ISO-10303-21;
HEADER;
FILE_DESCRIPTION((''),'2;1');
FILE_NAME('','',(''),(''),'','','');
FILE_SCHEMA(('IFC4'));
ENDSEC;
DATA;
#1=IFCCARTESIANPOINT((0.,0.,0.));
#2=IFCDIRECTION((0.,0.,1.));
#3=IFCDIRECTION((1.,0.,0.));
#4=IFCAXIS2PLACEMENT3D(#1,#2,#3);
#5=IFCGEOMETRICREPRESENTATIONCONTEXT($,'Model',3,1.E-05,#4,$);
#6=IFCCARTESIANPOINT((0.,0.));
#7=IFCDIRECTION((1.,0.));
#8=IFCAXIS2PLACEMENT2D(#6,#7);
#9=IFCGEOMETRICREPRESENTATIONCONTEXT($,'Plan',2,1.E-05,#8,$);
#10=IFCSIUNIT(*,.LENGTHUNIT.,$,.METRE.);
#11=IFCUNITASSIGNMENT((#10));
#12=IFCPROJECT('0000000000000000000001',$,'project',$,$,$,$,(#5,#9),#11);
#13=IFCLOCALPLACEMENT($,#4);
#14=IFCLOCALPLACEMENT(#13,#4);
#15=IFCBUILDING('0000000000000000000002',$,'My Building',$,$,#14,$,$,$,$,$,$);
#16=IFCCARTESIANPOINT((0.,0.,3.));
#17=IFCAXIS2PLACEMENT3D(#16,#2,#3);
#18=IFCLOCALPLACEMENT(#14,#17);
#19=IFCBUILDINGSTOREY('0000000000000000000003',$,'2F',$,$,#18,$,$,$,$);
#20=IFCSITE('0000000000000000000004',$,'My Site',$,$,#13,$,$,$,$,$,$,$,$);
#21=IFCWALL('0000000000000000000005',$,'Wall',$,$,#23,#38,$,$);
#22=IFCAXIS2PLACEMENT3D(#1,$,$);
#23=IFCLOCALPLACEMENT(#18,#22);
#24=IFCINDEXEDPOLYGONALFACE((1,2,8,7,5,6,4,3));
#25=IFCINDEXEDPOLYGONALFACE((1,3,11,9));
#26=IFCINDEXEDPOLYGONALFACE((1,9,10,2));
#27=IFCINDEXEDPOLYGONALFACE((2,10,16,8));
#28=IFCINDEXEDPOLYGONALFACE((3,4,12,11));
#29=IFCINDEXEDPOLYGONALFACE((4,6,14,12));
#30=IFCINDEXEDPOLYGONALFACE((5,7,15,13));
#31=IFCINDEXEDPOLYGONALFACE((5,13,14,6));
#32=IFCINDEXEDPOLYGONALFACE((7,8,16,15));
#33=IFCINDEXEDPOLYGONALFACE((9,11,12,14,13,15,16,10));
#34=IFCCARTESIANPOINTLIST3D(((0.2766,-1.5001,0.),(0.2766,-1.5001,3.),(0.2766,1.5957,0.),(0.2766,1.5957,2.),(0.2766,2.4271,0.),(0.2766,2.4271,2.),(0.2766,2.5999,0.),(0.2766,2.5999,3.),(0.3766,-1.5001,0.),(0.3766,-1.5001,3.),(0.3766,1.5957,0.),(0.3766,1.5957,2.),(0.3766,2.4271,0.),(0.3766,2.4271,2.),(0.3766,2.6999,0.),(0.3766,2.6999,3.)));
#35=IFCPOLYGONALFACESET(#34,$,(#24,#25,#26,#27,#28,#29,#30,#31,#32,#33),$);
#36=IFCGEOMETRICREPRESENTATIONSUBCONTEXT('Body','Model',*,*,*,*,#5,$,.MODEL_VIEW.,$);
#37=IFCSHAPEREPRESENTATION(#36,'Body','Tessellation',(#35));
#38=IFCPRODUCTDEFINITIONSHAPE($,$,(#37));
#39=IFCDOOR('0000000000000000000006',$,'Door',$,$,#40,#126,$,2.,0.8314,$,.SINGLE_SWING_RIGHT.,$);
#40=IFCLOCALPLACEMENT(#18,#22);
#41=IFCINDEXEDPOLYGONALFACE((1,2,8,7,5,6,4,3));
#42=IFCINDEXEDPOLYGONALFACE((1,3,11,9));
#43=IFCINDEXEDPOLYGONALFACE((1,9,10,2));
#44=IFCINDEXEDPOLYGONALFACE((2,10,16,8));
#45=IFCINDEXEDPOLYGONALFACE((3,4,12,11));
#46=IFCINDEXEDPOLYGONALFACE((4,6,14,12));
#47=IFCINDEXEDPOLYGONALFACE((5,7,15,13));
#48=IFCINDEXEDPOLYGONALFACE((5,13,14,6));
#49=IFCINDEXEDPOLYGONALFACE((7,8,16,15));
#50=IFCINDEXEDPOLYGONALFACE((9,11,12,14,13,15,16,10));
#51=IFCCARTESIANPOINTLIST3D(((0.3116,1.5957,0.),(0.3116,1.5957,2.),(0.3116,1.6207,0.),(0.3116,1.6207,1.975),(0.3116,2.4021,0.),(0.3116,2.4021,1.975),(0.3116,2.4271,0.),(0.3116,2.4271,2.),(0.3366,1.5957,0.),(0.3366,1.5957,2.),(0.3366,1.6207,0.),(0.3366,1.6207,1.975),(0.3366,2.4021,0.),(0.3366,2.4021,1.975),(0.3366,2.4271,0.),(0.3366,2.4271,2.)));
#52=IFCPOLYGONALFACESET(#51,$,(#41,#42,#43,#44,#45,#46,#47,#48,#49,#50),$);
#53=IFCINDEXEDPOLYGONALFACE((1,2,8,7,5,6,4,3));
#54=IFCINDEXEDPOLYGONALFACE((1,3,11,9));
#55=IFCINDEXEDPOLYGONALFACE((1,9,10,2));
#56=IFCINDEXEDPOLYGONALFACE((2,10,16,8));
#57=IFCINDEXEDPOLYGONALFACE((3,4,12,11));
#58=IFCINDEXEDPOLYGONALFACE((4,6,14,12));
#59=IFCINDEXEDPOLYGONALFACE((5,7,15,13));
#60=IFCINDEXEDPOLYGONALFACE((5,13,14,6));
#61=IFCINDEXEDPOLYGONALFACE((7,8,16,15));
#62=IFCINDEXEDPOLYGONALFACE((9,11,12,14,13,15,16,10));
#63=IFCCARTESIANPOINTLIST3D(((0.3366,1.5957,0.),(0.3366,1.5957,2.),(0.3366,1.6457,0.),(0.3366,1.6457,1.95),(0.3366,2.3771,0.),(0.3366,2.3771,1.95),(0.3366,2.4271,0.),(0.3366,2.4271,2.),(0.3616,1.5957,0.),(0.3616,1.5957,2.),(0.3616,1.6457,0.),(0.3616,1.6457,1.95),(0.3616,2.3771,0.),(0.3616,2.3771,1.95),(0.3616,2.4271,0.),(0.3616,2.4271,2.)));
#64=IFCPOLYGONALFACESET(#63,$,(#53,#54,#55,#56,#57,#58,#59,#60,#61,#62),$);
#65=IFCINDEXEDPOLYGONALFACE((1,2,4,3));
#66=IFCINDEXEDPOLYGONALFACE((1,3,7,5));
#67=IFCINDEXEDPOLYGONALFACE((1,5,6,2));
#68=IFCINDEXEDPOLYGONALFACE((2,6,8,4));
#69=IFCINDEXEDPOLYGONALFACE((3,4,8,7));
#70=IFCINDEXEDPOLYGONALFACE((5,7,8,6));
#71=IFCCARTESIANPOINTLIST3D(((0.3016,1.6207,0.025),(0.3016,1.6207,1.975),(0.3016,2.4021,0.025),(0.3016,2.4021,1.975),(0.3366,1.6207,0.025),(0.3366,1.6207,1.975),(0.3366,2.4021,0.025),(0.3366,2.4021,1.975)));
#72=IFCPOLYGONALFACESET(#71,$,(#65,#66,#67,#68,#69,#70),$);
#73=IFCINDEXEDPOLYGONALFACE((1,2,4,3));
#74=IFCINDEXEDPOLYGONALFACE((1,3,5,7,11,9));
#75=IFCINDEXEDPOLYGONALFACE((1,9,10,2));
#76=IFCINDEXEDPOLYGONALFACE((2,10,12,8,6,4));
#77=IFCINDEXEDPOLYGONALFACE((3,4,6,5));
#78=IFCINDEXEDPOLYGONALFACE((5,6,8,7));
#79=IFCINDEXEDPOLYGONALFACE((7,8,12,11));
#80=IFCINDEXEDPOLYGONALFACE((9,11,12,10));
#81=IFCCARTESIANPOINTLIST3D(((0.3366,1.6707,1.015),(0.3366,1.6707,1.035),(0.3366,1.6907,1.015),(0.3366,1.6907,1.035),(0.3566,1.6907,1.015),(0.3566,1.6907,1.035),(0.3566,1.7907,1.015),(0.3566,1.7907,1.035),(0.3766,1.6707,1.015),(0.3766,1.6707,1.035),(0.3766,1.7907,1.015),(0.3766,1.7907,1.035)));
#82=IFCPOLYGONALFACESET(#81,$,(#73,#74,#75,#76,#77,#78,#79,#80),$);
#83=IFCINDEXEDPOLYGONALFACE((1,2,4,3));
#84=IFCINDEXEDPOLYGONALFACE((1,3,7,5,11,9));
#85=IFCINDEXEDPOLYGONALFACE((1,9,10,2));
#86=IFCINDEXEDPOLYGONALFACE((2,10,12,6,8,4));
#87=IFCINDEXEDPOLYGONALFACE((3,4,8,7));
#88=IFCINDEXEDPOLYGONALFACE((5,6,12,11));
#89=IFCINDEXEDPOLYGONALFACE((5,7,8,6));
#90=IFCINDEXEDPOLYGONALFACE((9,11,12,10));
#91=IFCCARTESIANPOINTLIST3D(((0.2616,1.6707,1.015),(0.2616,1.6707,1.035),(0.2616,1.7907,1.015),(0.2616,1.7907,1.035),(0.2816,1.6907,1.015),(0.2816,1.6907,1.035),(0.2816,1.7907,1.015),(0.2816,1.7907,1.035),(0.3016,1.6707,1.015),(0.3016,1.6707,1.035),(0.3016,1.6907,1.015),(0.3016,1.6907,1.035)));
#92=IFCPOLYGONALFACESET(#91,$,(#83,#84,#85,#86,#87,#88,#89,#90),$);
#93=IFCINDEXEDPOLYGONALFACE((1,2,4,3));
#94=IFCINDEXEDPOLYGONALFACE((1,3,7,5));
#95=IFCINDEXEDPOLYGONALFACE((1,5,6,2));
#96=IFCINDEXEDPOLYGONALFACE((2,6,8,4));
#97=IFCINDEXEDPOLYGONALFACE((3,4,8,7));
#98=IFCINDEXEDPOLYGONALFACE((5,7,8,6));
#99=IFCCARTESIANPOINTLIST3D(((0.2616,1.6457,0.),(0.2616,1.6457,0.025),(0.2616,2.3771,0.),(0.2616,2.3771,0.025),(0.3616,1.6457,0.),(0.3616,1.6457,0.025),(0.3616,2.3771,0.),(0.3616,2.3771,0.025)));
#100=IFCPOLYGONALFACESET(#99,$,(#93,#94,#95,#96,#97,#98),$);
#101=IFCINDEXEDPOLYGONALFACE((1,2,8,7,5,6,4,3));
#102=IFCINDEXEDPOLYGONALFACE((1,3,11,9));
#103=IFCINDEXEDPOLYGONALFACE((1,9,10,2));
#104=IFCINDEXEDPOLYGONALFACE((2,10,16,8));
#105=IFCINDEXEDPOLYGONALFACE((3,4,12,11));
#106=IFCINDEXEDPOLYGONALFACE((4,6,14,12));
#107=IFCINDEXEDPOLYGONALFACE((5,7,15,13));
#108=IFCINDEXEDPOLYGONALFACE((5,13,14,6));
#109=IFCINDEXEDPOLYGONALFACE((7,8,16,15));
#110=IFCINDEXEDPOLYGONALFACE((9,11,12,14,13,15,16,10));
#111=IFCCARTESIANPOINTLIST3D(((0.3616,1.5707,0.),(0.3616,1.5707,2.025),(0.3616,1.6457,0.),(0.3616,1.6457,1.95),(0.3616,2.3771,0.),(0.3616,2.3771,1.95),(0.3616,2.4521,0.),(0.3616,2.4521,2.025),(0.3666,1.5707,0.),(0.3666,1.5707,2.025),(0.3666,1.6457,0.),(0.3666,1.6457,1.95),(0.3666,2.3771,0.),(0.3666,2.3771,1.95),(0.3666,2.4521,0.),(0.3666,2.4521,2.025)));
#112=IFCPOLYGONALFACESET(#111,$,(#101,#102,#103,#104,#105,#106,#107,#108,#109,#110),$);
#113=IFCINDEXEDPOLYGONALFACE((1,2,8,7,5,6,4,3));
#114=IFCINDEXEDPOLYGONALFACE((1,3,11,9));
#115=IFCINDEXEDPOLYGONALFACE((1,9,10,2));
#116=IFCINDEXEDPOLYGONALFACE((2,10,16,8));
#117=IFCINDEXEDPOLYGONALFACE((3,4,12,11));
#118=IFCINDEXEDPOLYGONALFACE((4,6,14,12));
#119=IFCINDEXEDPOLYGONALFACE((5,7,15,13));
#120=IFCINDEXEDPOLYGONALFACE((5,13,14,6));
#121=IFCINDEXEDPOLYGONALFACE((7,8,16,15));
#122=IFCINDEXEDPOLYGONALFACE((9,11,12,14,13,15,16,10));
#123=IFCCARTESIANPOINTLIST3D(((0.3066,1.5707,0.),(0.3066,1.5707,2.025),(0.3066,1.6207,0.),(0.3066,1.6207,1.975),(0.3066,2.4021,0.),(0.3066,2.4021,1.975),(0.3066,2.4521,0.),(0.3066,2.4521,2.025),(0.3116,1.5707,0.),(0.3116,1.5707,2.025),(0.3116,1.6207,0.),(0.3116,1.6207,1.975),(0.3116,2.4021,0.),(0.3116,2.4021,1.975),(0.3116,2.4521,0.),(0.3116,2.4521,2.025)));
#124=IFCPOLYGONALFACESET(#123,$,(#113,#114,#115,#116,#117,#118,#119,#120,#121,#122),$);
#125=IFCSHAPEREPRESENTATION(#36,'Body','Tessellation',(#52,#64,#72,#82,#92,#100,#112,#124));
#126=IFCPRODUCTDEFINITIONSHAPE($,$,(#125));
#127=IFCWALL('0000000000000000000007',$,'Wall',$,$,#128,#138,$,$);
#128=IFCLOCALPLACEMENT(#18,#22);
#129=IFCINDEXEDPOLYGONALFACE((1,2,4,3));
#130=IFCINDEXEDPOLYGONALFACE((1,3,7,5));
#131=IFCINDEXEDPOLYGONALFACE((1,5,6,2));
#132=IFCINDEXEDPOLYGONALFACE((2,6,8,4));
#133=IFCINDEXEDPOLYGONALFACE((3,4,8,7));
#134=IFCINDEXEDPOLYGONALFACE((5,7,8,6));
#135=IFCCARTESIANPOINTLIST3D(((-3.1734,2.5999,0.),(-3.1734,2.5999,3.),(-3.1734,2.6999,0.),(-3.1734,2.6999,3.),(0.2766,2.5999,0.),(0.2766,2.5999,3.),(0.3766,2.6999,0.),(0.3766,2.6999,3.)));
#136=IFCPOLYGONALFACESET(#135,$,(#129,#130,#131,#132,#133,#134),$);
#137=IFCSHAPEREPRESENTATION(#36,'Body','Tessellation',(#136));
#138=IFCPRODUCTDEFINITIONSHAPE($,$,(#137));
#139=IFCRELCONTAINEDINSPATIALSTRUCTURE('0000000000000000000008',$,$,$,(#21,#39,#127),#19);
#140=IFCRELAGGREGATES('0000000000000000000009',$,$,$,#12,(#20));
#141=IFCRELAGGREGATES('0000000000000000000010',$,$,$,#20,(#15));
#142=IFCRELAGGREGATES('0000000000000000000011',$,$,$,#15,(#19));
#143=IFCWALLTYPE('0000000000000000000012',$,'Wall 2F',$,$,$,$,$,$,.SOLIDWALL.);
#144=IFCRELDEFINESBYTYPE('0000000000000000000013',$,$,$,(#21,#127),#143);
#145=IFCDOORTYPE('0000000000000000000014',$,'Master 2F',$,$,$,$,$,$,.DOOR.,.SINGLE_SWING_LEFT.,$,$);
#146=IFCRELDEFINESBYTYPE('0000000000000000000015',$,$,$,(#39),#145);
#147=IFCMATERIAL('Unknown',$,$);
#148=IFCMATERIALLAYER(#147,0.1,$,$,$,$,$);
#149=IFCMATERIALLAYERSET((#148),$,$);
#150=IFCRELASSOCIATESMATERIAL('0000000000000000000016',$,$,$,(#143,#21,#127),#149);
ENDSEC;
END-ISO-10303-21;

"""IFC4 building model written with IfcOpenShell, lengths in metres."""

from ifc_helpers import new_model, entity, si_unit, frame, origin_with_axes, origin_2d_with_axis, place, context, subcontext, project, spatial, line, indexed_curve, outline, extrude, shape, source, transform, mapped, material, layer, layer_set, layer_usage, type_object, type_shapes, element, fill, save


model = new_model("IFC4")

# Units and contexts
model_context = context("Model", 3, precision=1e-05, world=origin_with_axes())
plan_context = context("Plan", 2, precision=1e-05, world=origin_2d_with_axis())
body_context_1 = subcontext(model_context, "Body", "Model", "MODEL_VIEW")
body_context_2 = subcontext(plan_context, "Body", "Plan", "PLAN_VIEW")
ifc_project = project(units=[si_unit("LENGTHUNIT", "METRE")], contexts=[model_context, plan_context])

# Site, building, storey
site_placement = place(None, origin_with_axes())
site = spatial("IfcSite", under=ifc_project, at=site_placement, Name="My Site")
building_placement = place(site_placement, origin_with_axes())
building = spatial("IfcBuilding", under=site, at=building_placement, Name="My Building")
storey_placement = place(building_placement, frame((0.0, 0.0, 3.0), z_axis=(0.0, 0.0, 1.0), x_axis=(1.0, 0.0, 0.0)))
storey = spatial("IfcBuildingStorey", under=building, at=storey_placement, Name="2F")

# Shared definitions
ifc_material = material(Name="Unknown")
ifc_layer_1 = layer(ifc_material, 0.1)
ifc_layer_set_1 = layer_set([ifc_layer_1])
wall_type_1 = type_object("IfcWallType", Name="Wall 2F", PredefinedType="SOLIDWALL", material=ifc_layer_set_1)

# Wall, opening, door
ifc_layer_usage_1 = layer_usage(ifc_layer_set_1, "AXIS2", "POSITIVE", 0.0)
wall_1_placement = place(storey_placement, frame((0.3766, -1.6001, 0.0), z_axis=(0.0, 0.0, 1.0), x_axis=(0.0, 1.0, 0.0)))
wall_1 = element("IfcWall", 1, at=wall_1_placement, inside=storey, type_object=wall_type_1, material=ifc_layer_usage_1, Name="Wall", context=body_context_1, shape_type="SweptSolid", body=[
    extrude(outline(indexed_curve([(0.1, 0.0), (0.1, 0.1), (4.2, 0.1), (4.3, 0.0)], segments=[line(1, 2, 3, 4, 1)])), origin_with_axes(), (0.0, 0.0, 1.0), 3.0),
])
shared_shape_1 = source(origin_with_axes(), body_context_1, "Body", "SweptSolid", [
    extrude(outline(indexed_curve([(0.0, 0.0), (0.8314, 0.0), (0.8314, 2.0), (0.0, 2.0)], segments=[line(1, 2, 3, 4, 1)])), frame((0.0, -0.6, 0.0), z_axis=(0.0, -1.0, 0.0), x_axis=(1.0, 0.0, 0.0)), (0.0, 0.0, -1.0), 1.2),
])
opening_1_placement = place(wall_1_placement, frame((3.1958, 0.015, 0.0), z_axis=(0.0, 0.0, 1.0), x_axis=(1.0, 0.0, 0.0)))
opening_1 = element("IfcOpeningElement", 2, at=opening_1_placement, cuts=wall_1, PredefinedType="OPENING", context=body_context_1, shape_type="MappedRepresentation", body=[
    mapped(shared_shape_1, transform((0.0, 0.0, 0.0), x_axis=(1.0, 0.0, 0.0), y_axis=(0.0, 1.0, 0.0), z_axis=(0.0, 0.0, 1.0), scale=1.0)),
])
door_type_1 = type_object("IfcDoorType", Name="Master 2F", OperationType="SINGLE_SWING_LEFT", PredefinedType="DOOR")
shared_shape_2 = source(origin_with_axes(), body_context_1, "Body", "SweptSolid", [
    extrude(outline(indexed_curve([(0.0, 0.0), (0.0, 2.0), (0.8314, 2.0), (0.8314, 0.0), (0.8064, 0.0), (0.8064, 1.975), (0.025, 1.975), (0.025, 0.0)], segments=[line(1, 2, 3, 4, 5, 6, 7, 8, 1)])), frame((0.0, 0.025, 0.0), z_axis=(0.0, -1.0, 0.0), x_axis=(1.0, 0.0, 0.0)), (0.0, 0.0, -1.0), 0.025),
    extrude(outline(indexed_curve([(0.0, 0.0), (0.0, 2.0), (0.8314, 2.0), (0.8314, 0.0), (0.7814, 0.0), (0.7814, 1.95), (0.05, 1.95), (0.05, 0.0)], segments=[line(1, 2, 3, 4, 5, 6, 7, 8, 1)])), frame((0.0, 0.0, 0.0), z_axis=(0.0, -1.0, 0.0), x_axis=(1.0, 0.0, 0.0)), (0.0, 0.0, -1.0), 0.025),
    extrude(outline(indexed_curve([(0.0, 0.0), (0.7814, 0.0), (0.7814, 0.035), (0.0, 0.035)], segments=[line(1, 2, 3, 4, 1)])), frame((0.025, 0.025, 0.025), z_axis=(0.0, 0.0, 1.0), x_axis=(1.0, 0.0, 0.0)), (0.0, 0.0, 1.0), 1.95),
    extrude(outline(indexed_curve([(0.0, 0.0), (0.0, -0.04), (0.12, -0.04), (0.12, -0.02), (0.02, -0.02), (0.02, 0.0)], segments=[line(1, 2, 3, 4, 5, 6, 1)])), frame((0.075, 0.025, 1.015), z_axis=(0.0, 0.0, 1.0), x_axis=(1.0, 0.0, 0.0)), (0.0, 0.0, 1.0), 0.02),
    extrude(outline(indexed_curve([(0.0, 0.0), (0.0, 0.04), (0.12, 0.04), (0.12, 0.02), (0.02, 0.02), (0.02, 0.0)], segments=[line(1, 2, 3, 4, 5, 6, 1)])), frame((0.075, 0.06, 1.015), z_axis=(0.0, 0.0, 1.0), x_axis=(1.0, 0.0, 0.0)), (0.0, 0.0, 1.0), 0.02),
    extrude(outline(indexed_curve([(0.0, 0.0), (0.7314, 0.0), (0.7314, 0.1), (0.0, 0.1)], segments=[line(1, 2, 3, 4, 1)])), frame((0.05, 0.0, 0.0), z_axis=(0.0, 0.0, 1.0), x_axis=(1.0, 0.0, 0.0)), (0.0, 0.0, 1.0), 0.025),
    extrude(outline(indexed_curve([(0.0, 0.0), (0.0, 2.025), (0.8814, 2.025), (0.8814, 0.0), (0.8064, 0.0), (0.8064, 1.95), (0.075, 1.95), (0.075, 0.0)], segments=[line(1, 2, 3, 4, 5, 6, 7, 8, 1)])), frame((-0.025, -0.005, 0.0), z_axis=(0.0, -1.0, 0.0), x_axis=(1.0, 0.0, 0.0)), (0.0, 0.0, -1.0), 0.005),
    extrude(outline(indexed_curve([(0.0, 0.0), (0.0, 2.025), (0.8814, 2.025), (0.8814, 0.0), (0.8314, 0.0), (0.8314, 1.975), (0.05, 1.975), (0.05, 0.0)], segments=[line(1, 2, 3, 4, 5, 6, 7, 8, 1)])), frame((-0.025, 0.05, 0.0), z_axis=(0.0, -1.0, 0.0), x_axis=(1.0, 0.0, 0.0)), (0.0, 0.0, -1.0), 0.005),
])
shared_shape_3 = source(origin_with_axes(), body_context_2, "Body", "Curve2D", [
    entity("IfcIndexedPolyCurve", entity("IfcCartesianPointList2D", [[0.0, 0.0], [0.0, 0.05], [0.025, 0.05], [0.025, 0.025], [0.05, 0.025], [0.05, 0.0]]), [entity("IfcLineIndex", [1, 2, 3, 4, 5, 6, 1])]),
    entity("IfcIndexedPolyCurve", entity("IfcCartesianPointList2D", [[0.8314, 0.0], [0.8314, 0.05], [0.8064, 0.05], [0.8064, 0.025], [0.7814, 0.025], [0.7814, 0.0]]), [entity("IfcLineIndex", [1, 2, 3, 4, 5, 6, 1])]),
    entity("IfcTrimmedCurve", entity("IfcEllipse", entity("IfcAxis2Placement2D", entity("IfcCartesianPoint", [0.7714, 0.05]), entity("IfcDirection", [1.0, 0.0])), 0.7464, 0.7814), [entity("IfcCartesianPoint", [0.7714, 0.8314])], [entity("IfcCartesianPoint", [0.025, 0.05])], True, "CARTESIAN"),
    entity("IfcIndexedPolyCurve", entity("IfcCartesianPointList2D", [[0.8064, 0.05], [0.7714, 0.05], [0.7714, 0.8314], [0.8064, 0.8314]]), [entity("IfcLineIndex", [1, 2, 3, 4, 1])]),
])
type_shapes(door_type_1, [shared_shape_2, shared_shape_3])
door_1_placement = place(opening_1_placement, frame((0.0, 0.0, 0.0), z_axis=(0.0, 0.0, 1.0), x_axis=(1.0, 0.0, 0.0)))
door_1 = element("IfcDoor", 3, at=door_1_placement, inside=storey, type_object=door_type_1, Name="Door", OperationType="SINGLE_SWING_RIGHT", OverallHeight=2.0, OverallWidth=0.8314, shapes=[
    shape(body_context_1, "Body", "MappedRepresentation", [mapped(shared_shape_2, transform((0.0, 0.0, 0.0), x_axis=(1.0, 0.0, 0.0), y_axis=(0.0, 1.0, 0.0), z_axis=(0.0, 0.0, 1.0), scale=1.0))]),
    shape(body_context_2, "Body", "MappedRepresentation", [mapped(shared_shape_3, transform((0.0, 0.0, 0.0), x_axis=(1.0, 0.0, 0.0), y_axis=(0.0, 1.0, 0.0), z_axis=(0.0, 0.0, 1.0), scale=1.0))]),
])
fill(opening_1, door_1)

# Wall
ifc_layer_usage_2 = layer_usage(ifc_layer_set_1, "AXIS2", "POSITIVE", 0.0)
wall_2_placement = place(storey_placement, frame((0.3766, 2.6999, 0.0), z_axis=(0.0, 0.0, 1.0), x_axis=(-1.0, 0.0, 0.0)))
element("IfcWall", 4, at=wall_2_placement, inside=storey, type_object=wall_type_1, material=ifc_layer_usage_2, Name="Wall", context=body_context_1, shape_type="SweptSolid", body=[
    extrude(outline(indexed_curve([(0.0, 0.0), (0.1, 0.1), (3.55, 0.1), (3.55, 0.0)], segments=[line(1, 2, 3, 4, 1)])), origin_with_axes(), (0.0, 0.0, 1.0), 3.0),
])

save(model, "model.ifc")
